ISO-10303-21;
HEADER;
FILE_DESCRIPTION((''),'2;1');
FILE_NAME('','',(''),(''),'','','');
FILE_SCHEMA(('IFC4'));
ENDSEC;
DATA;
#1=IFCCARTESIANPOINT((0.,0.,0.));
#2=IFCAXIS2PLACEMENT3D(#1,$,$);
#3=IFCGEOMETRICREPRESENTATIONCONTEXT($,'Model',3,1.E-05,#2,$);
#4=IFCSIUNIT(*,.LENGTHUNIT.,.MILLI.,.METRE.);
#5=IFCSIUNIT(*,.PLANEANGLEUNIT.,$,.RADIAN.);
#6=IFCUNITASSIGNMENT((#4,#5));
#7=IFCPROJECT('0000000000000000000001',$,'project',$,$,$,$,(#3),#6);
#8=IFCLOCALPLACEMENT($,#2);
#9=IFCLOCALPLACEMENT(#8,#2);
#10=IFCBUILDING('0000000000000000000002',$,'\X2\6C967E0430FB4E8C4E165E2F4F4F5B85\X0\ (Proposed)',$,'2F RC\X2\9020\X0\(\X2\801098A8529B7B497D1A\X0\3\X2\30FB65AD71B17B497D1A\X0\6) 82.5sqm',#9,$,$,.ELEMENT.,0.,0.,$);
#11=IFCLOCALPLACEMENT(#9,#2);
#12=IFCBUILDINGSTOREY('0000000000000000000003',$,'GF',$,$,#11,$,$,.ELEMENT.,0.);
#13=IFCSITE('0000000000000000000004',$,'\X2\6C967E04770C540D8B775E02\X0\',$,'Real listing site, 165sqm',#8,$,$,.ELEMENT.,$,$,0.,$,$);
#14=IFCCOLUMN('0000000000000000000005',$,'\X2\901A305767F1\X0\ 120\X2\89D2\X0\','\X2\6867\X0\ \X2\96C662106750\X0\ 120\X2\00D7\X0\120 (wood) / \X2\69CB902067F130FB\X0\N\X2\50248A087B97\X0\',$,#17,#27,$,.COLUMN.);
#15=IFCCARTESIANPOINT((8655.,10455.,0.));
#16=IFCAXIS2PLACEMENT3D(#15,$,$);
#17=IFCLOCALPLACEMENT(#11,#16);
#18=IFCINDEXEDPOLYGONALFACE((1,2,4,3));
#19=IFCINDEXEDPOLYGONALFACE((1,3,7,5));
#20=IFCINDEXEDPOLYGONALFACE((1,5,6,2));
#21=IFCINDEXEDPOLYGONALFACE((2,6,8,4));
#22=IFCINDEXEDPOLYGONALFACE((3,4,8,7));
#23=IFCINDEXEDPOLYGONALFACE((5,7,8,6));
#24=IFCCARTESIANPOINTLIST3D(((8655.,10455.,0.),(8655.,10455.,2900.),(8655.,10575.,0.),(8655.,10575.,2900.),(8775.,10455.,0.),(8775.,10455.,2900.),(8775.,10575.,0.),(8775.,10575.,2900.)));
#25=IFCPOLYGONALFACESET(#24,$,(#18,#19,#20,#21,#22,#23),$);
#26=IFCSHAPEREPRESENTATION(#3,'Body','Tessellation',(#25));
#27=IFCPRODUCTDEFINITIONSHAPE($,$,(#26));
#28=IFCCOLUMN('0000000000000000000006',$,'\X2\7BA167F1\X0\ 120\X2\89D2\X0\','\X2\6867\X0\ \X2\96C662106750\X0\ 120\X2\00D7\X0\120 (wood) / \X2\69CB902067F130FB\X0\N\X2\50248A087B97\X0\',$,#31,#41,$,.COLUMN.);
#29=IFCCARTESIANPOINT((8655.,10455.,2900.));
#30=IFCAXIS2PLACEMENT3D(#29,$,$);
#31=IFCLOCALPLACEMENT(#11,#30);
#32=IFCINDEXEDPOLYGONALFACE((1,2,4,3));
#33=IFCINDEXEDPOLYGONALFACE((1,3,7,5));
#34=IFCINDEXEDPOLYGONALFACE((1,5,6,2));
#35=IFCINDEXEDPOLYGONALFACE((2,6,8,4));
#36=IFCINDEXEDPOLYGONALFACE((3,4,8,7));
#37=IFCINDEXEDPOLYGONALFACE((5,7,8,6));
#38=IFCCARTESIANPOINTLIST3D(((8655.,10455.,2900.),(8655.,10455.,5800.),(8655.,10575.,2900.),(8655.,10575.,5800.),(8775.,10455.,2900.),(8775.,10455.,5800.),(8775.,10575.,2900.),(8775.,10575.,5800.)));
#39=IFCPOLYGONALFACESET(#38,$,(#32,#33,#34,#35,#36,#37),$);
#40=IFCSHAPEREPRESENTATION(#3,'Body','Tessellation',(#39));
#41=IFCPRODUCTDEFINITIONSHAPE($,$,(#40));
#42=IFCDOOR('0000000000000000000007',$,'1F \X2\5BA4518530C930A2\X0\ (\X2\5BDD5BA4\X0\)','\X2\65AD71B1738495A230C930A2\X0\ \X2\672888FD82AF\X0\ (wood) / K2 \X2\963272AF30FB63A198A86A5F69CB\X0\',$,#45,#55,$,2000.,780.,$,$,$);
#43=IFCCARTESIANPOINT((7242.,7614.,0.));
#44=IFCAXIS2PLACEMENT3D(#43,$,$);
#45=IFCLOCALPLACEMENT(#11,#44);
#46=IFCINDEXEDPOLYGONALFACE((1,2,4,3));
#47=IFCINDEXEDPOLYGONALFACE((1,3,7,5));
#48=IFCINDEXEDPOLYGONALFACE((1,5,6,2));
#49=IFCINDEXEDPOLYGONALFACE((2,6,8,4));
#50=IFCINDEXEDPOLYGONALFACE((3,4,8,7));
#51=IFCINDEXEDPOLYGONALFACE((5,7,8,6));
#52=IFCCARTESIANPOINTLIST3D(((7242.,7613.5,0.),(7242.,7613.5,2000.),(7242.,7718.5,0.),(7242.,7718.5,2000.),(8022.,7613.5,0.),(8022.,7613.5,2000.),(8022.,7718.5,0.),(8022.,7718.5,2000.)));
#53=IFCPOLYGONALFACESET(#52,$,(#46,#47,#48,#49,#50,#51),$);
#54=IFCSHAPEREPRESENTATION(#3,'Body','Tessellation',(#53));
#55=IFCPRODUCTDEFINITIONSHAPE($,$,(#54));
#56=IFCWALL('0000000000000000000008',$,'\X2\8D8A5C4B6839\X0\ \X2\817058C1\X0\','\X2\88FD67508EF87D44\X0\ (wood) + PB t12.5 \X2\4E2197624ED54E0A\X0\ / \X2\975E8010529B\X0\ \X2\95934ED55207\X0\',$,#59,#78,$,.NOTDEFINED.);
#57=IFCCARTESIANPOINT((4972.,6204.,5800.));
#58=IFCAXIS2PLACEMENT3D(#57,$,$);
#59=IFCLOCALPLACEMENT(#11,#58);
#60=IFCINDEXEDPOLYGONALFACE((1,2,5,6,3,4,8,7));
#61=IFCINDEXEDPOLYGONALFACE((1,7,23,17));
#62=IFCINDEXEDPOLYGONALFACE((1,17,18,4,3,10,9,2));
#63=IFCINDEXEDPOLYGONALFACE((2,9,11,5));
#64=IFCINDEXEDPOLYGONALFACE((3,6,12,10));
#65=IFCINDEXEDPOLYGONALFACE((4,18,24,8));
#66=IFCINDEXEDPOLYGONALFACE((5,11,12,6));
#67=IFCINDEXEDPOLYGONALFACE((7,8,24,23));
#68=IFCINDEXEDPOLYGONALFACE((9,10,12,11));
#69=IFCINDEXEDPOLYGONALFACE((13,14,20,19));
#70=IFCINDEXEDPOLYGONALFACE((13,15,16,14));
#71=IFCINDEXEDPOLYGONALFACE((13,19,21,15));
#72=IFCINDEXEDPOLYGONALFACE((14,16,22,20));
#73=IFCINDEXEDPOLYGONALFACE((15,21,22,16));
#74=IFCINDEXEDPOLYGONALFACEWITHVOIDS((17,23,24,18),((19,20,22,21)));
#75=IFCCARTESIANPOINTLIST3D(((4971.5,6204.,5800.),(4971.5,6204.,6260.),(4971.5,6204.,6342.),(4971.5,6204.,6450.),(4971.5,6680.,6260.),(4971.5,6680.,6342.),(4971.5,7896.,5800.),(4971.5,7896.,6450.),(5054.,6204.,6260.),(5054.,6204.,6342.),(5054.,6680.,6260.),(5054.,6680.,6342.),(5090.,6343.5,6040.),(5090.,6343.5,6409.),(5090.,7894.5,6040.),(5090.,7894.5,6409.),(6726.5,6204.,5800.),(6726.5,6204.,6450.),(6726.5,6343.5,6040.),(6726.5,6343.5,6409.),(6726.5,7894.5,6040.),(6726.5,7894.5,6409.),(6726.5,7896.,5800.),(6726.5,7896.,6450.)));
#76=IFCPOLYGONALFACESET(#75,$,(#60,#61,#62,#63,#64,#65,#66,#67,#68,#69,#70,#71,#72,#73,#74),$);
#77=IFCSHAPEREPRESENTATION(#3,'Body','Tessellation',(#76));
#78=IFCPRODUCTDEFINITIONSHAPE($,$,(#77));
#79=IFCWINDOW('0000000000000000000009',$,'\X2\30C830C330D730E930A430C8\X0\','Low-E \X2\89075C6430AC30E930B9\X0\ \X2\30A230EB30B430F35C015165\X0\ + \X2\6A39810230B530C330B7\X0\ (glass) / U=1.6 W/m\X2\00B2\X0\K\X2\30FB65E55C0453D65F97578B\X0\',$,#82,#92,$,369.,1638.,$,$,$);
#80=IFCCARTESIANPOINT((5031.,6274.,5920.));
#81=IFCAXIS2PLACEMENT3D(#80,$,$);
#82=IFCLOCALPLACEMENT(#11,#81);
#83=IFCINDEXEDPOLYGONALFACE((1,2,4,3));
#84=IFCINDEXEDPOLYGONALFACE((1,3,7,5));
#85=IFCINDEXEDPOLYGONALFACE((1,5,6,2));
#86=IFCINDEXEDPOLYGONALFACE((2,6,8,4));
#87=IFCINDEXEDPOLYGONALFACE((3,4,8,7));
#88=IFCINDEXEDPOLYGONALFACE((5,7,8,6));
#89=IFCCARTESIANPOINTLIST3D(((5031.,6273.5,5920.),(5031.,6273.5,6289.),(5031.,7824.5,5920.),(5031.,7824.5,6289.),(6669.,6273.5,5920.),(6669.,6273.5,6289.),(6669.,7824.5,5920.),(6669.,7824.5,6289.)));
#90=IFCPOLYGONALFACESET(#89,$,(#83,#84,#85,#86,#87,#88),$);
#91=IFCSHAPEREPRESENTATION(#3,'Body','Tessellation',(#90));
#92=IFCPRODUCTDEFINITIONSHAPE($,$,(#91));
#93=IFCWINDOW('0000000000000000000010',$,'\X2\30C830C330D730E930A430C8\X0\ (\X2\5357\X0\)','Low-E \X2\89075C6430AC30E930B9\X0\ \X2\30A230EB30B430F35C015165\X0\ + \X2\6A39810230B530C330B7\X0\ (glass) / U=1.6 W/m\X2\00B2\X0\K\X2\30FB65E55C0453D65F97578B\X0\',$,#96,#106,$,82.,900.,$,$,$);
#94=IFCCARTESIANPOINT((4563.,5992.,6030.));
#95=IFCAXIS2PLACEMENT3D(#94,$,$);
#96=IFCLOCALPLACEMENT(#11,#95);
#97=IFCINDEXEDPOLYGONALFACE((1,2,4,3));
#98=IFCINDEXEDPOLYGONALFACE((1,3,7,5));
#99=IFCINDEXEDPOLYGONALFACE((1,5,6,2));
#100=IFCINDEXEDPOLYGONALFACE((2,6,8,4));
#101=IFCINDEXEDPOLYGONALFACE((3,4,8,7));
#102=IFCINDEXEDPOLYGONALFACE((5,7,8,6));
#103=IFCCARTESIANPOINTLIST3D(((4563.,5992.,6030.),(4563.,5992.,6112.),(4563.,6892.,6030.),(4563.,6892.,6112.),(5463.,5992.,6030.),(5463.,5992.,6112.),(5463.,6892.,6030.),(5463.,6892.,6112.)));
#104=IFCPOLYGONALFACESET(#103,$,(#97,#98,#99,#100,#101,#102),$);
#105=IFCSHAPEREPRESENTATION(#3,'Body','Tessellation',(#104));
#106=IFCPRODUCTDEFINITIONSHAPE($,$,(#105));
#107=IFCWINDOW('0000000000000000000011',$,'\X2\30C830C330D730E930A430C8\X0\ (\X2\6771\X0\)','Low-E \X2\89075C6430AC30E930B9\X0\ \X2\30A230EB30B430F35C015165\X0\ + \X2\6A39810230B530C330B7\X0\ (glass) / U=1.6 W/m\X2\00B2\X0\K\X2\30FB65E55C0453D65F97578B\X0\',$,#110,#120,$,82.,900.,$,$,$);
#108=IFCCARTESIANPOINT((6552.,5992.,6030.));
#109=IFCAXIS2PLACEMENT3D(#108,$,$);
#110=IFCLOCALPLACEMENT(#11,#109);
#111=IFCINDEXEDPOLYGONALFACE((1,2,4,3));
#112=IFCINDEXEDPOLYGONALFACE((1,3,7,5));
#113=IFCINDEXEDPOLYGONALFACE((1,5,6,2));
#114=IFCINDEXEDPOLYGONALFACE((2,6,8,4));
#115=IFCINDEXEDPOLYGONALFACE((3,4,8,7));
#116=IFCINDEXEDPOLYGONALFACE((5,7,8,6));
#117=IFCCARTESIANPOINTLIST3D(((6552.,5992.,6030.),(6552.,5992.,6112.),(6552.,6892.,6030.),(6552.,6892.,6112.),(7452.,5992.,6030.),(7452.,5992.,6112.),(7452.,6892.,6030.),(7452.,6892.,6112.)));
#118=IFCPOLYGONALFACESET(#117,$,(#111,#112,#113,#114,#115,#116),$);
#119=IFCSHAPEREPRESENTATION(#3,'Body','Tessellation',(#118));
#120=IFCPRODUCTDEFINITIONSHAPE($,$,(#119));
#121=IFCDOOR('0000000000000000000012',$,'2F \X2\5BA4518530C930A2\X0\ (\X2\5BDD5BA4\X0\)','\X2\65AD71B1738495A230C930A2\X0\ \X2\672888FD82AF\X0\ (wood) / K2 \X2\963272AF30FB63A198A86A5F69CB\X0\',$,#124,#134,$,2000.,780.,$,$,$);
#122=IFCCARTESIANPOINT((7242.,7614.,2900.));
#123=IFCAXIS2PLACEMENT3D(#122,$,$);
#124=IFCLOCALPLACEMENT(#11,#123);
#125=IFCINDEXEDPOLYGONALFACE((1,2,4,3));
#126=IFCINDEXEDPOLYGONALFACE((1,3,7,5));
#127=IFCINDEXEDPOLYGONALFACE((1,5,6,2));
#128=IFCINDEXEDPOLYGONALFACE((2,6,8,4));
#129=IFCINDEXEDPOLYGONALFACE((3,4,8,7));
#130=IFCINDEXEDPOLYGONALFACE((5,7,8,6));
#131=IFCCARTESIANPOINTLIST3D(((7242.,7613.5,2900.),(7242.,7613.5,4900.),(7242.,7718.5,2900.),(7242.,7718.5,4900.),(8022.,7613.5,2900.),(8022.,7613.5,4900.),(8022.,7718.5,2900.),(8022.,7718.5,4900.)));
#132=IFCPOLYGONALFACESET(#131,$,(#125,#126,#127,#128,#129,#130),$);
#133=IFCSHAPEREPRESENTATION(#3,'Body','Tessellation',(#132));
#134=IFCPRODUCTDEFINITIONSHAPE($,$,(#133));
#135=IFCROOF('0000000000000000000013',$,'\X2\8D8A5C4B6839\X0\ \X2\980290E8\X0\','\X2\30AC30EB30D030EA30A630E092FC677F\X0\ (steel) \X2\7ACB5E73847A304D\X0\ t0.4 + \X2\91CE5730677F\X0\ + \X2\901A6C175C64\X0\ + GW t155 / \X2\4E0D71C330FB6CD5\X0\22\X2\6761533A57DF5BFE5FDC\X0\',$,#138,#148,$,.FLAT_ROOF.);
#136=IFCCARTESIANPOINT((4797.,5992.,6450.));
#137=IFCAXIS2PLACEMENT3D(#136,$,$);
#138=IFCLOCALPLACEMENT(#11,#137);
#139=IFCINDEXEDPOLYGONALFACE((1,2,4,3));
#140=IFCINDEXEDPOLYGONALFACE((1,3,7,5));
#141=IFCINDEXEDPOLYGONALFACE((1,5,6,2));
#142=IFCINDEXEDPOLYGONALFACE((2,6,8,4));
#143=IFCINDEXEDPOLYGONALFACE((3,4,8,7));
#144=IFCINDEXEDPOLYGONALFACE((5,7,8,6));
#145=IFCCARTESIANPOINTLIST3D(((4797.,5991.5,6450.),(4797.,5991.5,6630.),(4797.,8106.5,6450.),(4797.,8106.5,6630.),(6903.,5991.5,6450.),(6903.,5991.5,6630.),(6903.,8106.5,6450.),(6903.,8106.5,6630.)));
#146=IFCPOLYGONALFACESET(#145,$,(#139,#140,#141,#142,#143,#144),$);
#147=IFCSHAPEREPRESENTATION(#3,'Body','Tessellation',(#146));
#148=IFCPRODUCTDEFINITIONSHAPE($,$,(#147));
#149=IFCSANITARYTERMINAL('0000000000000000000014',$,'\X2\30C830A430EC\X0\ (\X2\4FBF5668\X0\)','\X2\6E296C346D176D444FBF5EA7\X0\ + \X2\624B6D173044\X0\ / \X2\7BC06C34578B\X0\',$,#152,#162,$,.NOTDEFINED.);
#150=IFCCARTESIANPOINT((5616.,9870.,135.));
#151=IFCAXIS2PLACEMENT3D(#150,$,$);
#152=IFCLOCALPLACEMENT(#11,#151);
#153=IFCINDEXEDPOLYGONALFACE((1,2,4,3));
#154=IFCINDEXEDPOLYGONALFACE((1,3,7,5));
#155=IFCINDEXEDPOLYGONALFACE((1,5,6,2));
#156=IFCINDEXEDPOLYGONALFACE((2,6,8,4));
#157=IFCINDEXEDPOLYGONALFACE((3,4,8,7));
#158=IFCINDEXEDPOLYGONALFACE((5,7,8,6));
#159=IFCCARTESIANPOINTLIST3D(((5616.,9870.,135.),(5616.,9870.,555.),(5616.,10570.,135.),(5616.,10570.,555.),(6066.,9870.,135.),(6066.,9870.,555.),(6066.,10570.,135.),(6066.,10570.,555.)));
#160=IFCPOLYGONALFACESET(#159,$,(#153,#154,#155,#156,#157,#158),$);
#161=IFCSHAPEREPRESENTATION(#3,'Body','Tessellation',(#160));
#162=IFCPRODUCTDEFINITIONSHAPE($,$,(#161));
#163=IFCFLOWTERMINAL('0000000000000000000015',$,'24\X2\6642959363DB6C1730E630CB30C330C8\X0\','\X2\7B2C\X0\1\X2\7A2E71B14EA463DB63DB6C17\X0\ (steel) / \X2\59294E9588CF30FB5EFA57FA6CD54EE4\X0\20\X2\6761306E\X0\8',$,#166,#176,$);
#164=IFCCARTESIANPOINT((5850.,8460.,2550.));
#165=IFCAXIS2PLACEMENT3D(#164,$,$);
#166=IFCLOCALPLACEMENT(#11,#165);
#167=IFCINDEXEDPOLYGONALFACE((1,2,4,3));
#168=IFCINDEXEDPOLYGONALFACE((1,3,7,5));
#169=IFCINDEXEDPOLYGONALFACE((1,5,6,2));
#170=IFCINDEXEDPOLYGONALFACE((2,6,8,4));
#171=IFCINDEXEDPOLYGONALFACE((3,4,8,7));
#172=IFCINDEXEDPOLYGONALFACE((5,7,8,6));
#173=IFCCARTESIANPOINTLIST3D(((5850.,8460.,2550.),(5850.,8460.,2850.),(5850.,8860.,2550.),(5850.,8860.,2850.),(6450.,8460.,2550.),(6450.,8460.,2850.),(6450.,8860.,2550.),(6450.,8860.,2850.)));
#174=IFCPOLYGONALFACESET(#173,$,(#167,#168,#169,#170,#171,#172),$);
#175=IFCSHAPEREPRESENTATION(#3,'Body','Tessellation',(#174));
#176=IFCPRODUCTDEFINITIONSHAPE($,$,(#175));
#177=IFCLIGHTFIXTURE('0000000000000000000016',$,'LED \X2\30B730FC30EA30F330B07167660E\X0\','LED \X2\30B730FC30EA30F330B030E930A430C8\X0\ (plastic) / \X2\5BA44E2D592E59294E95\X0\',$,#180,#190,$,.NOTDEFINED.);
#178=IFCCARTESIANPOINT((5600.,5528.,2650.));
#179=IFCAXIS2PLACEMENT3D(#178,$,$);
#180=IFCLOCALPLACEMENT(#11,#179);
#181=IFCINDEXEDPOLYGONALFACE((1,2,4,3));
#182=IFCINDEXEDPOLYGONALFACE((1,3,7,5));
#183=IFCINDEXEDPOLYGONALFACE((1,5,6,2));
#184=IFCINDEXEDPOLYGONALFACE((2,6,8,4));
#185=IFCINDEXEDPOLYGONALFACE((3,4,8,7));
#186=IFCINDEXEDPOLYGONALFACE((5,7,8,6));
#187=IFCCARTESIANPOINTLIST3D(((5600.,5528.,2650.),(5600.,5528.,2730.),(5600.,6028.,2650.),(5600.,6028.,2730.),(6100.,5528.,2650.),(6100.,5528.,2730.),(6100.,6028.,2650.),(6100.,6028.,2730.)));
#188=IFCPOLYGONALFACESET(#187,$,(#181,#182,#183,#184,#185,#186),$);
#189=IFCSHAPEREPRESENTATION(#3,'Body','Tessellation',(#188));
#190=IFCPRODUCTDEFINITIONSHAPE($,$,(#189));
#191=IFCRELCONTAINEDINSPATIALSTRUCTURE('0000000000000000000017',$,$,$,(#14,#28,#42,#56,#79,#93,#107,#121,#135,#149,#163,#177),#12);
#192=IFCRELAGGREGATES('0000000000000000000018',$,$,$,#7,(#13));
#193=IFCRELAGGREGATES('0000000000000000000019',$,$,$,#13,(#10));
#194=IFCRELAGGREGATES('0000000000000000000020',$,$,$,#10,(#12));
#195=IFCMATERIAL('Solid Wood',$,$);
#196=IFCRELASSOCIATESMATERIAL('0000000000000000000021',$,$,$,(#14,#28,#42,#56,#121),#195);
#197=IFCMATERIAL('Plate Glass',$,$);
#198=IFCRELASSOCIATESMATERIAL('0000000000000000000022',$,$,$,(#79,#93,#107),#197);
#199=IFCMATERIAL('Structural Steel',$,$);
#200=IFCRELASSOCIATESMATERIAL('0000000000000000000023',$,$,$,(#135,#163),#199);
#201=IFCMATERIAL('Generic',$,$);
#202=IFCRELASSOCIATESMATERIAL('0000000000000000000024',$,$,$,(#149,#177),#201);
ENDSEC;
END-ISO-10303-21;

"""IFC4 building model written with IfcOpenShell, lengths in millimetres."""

from ifc_helpers import new_model, si_unit, frame, frame_2d, origin, place, context, project, spatial, rectangle, extrude, material, element, fill, save


model = new_model("IFC4")

# Units and contexts
model_context = context("Model", 3, precision=1e-05, world=origin())
ifc_project = project(units=[si_unit("LENGTHUNIT", "METRE", prefix="MILLI"), si_unit("PLANEANGLEUNIT", "RADIAN")], contexts=[model_context])

# Site, building, storey
site_placement = place(None, origin())
site = spatial("IfcSite", under=ifc_project, at=site_placement, Name="沖縄県名護市", ObjectType="Real listing site, 165sqm", CompositionType="ELEMENT", RefElevation=0.0)
building_placement = place(site_placement, origin())
building = spatial("IfcBuilding", under=site, at=building_placement, Name="沖縄・二世帯住宅 (Proposed)", ObjectType="2F RC造(耐風力等級3・断熱等級6) 82.5sqm", CompositionType="ELEMENT", ElevationOfRefHeight=0.0, ElevationOfTerrain=0.0)
storey_placement = place(building_placement, origin())
storey = spatial("IfcBuildingStorey", under=building, at=storey_placement, Name="GF", CompositionType="ELEMENT", Elevation=0.0)

# Columns
ifc_material_1 = material(Name="Solid Wood")
column_1_placement = place(storey_placement, frame((8655.0, 10455.0, 0.0)))
element("IfcColumn", 1, at=column_1_placement, inside=storey, material=ifc_material_1, Name="通し柱 120角", Description="桧 集成材 120×120 (wood) / 構造柱・N値計算", PredefinedType="COLUMN", context=model_context, shape_type="SweptSolid", body=[
    extrude(rectangle(XDim=120.0, YDim=120.0, at=frame_2d((60.0, 60.0))), frame((8655.0, 10455.0, 0.0)), (0.0, 0.0, 1.0), 2900.0),
])
column_2_placement = place(storey_placement, frame((8655.0, 10455.0, 2900.0)))
element("IfcColumn", 2, at=column_2_placement, inside=storey, material=ifc_material_1, Name="管柱 120角", Description="桧 集成材 120×120 (wood) / 構造柱・N値計算", PredefinedType="COLUMN", context=model_context, shape_type="SweptSolid", body=[
    extrude(rectangle(XDim=120.0, YDim=120.0, at=frame_2d((60.0, 60.0))), frame((8655.0, 10455.0, 2900.0)), (0.0, 0.0, 1.0), 2900.0),
])

# Door
door_1_placement = place(storey_placement, frame((7242.0, 7614.0, 0.0)))
element("IfcDoor", 3, at=door_1_placement, inside=storey, material=ifc_material_1, Name="1F 室内ドア (寝室)", Description="断熱玄関ドア 木製芯 (wood) / K2 防犯・採風機構", OverallHeight=2000.0, OverallWidth=780.0, context=model_context, shape_type="SweptSolid", body=[
    extrude(rectangle(XDim=780.0, YDim=105.0, at=frame_2d((390.0, 52.0))), frame((7242.0, 7614.0, 0.0)), (0.0, 0.0, 1.0), 2000.0),
])

# Wall, openings, windows
wall_1_placement = place(storey_placement, frame((4972.0, 6204.0, 5800.0)))
wall_1 = element("IfcWall", 4, at=wall_1_placement, inside=storey, material=ifc_material_1, Name="越屋根 腰壁", Description="製材軸組 (wood) + PB t12.5 両面仕上 / 非耐力 間仕切", PredefinedType="NOTDEFINED", context=model_context, shape_type="SweptSolid", body=[
    extrude(rectangle(XDim=1755.0, YDim=1692.0, at=frame_2d((877.0, 846.0))), frame((4972.0, 6204.0, 5800.0)), (0.0, 0.0, 1.0), 650.0),
])
opening_1_placement = place(storey_placement, frame((5031.0, 6274.0, 5920.0)))
opening_1 = element("IfcOpeningElement", 5, at=opening_1_placement, cuts=wall_1, PredefinedType="NOTDEFINED", context=model_context, shape_type="SweptSolid", body=[
    extrude(rectangle(XDim=1638.0, YDim=1551.0, at=frame_2d((819.0, 775.0))), frame((5031.0, 6274.0, 5920.0)), (0.0, 0.0, 1.0), 369.0),
])
opening_2_placement = place(storey_placement, frame((4563.0, 5992.0, 6030.0)))
opening_2 = element("IfcOpeningElement", 6, at=opening_2_placement, cuts=wall_1, PredefinedType="NOTDEFINED", context=model_context, shape_type="SweptSolid", body=[
    extrude(rectangle(XDim=900.0, YDim=900.0, at=frame_2d((450.0, 450.0))), frame((4563.0, 5992.0, 6030.0)), (0.0, 0.0, 1.0), 82.0),
])
opening_3_placement = place(storey_placement, frame((6552.0, 5992.0, 6030.0)))
opening_3 = element("IfcOpeningElement", 7, at=opening_3_placement, cuts=wall_1, PredefinedType="NOTDEFINED", context=model_context, shape_type="SweptSolid", body=[
    extrude(rectangle(XDim=900.0, YDim=900.0, at=frame_2d((450.0, 450.0))), frame((6552.0, 5992.0, 6030.0)), (0.0, 0.0, 1.0), 82.0),
])
ifc_material_2 = material(Name="Plate Glass")
window_1_placement = place(storey_placement, frame((5031.0, 6274.0, 5920.0)))
window_1 = element("IfcWindow", 8, at=window_1_placement, inside=storey, material=ifc_material_2, Name="トップライト", Description="Low-E 複層ガラス アルゴン封入 + 樹脂サッシ (glass) / U=1.6 W/m²K・日射取得型", OverallHeight=369.0, OverallWidth=1638.0, context=model_context, shape_type="SweptSolid", body=[
    extrude(rectangle(XDim=1638.0, YDim=1551.0, at=frame_2d((819.0, 775.0))), frame((5031.0, 6274.0, 5920.0)), (0.0, 0.0, 1.0), 369.0),
])
fill(opening_1, window_1)
window_2_placement = place(storey_placement, frame((4563.0, 5992.0, 6030.0)))
window_2 = element("IfcWindow", 9, at=window_2_placement, inside=storey, material=ifc_material_2, Name="トップライト (南)", Description="Low-E 複層ガラス アルゴン封入 + 樹脂サッシ (glass) / U=1.6 W/m²K・日射取得型", OverallHeight=82.0, OverallWidth=900.0, context=model_context, shape_type="SweptSolid", body=[
    extrude(rectangle(XDim=900.0, YDim=900.0, at=frame_2d((450.0, 450.0))), frame((4563.0, 5992.0, 6030.0)), (0.0, 0.0, 1.0), 82.0),
])
fill(opening_2, window_2)
window_3_placement = place(storey_placement, frame((6552.0, 5992.0, 6030.0)))
window_3 = element("IfcWindow", 10, at=window_3_placement, inside=storey, material=ifc_material_2, Name="トップライト (東)", Description="Low-E 複層ガラス アルゴン封入 + 樹脂サッシ (glass) / U=1.6 W/m²K・日射取得型", OverallHeight=82.0, OverallWidth=900.0, context=model_context, shape_type="SweptSolid", body=[
    extrude(rectangle(XDim=900.0, YDim=900.0, at=frame_2d((450.0, 450.0))), frame((6552.0, 5992.0, 6030.0)), (0.0, 0.0, 1.0), 82.0),
])
fill(opening_3, window_3)

# Door
door_2_placement = place(storey_placement, frame((7242.0, 7614.0, 2900.0)))
element("IfcDoor", 11, at=door_2_placement, inside=storey, material=ifc_material_1, Name="2F 室内ドア (寝室)", Description="断熱玄関ドア 木製芯 (wood) / K2 防犯・採風機構", OverallHeight=2000.0, OverallWidth=780.0, context=model_context, shape_type="SweptSolid", body=[
    extrude(rectangle(XDim=780.0, YDim=105.0, at=frame_2d((390.0, 52.0))), frame((7242.0, 7614.0, 2900.0)), (0.0, 0.0, 1.0), 2000.0),
])

# Roof
ifc_material_3 = material(Name="Structural Steel")
roof_placement = place(storey_placement, frame((4797.0, 5992.0, 6450.0)))
element("IfcRoof", 12, at=roof_placement, inside=storey, material=ifc_material_3, Name="越屋根 頂部", Description="ガルバリウム鋼板 (steel) 立平葺き t0.4 + 野地板 + 通気層 + GW t155 / 不燃・法22条区域対応", PredefinedType="FLAT_ROOF", context=model_context, shape_type="SweptSolid", body=[
    extrude(rectangle(XDim=2106.0, YDim=2115.0, at=frame_2d((1053.0, 1057.0))), frame((4797.0, 5992.0, 6450.0)), (0.0, 0.0, 1.0), 180.0),
])

# Sanitary terminal
ifc_material_4 = material(Name="Generic")
sanitary_terminal_placement = place(storey_placement, frame((5616.0, 9870.0, 135.0)))
element("IfcSanitaryTerminal", 13, at=sanitary_terminal_placement, inside=storey, material=ifc_material_4, Name="トイレ (便器)", Description="温水洗浄便座 + 手洗い / 節水型", PredefinedType="NOTDEFINED", context=model_context, shape_type="SweptSolid", body=[
    extrude(rectangle(XDim=450.0, YDim=700.0, at=frame_2d((225.0, 350.0))), frame((5616.0, 9870.0, 135.0)), (0.0, 0.0, 1.0), 420.0),
])

# Flow terminal
flow_terminal_placement = place(storey_placement, frame((5850.0, 8460.0, 2550.0)))
element("IfcFlowTerminal", 14, at=flow_terminal_placement, inside=storey, material=ifc_material_3, Name="24時間換気ユニット", Description="第1種熱交換換気 (steel) / 天井裏・建基法令20条の8", context=model_context, shape_type="SweptSolid", body=[
    extrude(rectangle(XDim=600.0, YDim=400.0, at=frame_2d((300.0, 200.0))), frame((5850.0, 8460.0, 2550.0)), (0.0, 0.0, 1.0), 300.0),
])

# Light fixture
light_fixture_1_placement = place(storey_placement, frame((5600.0, 5528.0, 2650.0)))
element("IfcLightFixture", 15, at=light_fixture_1_placement, inside=storey, material=ifc_material_4, Name="LED シーリング照明", Description="LED シーリングライト (plastic) / 室中央天井", PredefinedType="NOTDEFINED", context=model_context, shape_type="SweptSolid", body=[
    extrude(rectangle(XDim=500.0, YDim=500.0, at=frame_2d((250.0, 250.0))), frame((5600.0, 5528.0, 2650.0)), (0.0, 0.0, 1.0), 80.0),
])

save(model, "model.ifc")
